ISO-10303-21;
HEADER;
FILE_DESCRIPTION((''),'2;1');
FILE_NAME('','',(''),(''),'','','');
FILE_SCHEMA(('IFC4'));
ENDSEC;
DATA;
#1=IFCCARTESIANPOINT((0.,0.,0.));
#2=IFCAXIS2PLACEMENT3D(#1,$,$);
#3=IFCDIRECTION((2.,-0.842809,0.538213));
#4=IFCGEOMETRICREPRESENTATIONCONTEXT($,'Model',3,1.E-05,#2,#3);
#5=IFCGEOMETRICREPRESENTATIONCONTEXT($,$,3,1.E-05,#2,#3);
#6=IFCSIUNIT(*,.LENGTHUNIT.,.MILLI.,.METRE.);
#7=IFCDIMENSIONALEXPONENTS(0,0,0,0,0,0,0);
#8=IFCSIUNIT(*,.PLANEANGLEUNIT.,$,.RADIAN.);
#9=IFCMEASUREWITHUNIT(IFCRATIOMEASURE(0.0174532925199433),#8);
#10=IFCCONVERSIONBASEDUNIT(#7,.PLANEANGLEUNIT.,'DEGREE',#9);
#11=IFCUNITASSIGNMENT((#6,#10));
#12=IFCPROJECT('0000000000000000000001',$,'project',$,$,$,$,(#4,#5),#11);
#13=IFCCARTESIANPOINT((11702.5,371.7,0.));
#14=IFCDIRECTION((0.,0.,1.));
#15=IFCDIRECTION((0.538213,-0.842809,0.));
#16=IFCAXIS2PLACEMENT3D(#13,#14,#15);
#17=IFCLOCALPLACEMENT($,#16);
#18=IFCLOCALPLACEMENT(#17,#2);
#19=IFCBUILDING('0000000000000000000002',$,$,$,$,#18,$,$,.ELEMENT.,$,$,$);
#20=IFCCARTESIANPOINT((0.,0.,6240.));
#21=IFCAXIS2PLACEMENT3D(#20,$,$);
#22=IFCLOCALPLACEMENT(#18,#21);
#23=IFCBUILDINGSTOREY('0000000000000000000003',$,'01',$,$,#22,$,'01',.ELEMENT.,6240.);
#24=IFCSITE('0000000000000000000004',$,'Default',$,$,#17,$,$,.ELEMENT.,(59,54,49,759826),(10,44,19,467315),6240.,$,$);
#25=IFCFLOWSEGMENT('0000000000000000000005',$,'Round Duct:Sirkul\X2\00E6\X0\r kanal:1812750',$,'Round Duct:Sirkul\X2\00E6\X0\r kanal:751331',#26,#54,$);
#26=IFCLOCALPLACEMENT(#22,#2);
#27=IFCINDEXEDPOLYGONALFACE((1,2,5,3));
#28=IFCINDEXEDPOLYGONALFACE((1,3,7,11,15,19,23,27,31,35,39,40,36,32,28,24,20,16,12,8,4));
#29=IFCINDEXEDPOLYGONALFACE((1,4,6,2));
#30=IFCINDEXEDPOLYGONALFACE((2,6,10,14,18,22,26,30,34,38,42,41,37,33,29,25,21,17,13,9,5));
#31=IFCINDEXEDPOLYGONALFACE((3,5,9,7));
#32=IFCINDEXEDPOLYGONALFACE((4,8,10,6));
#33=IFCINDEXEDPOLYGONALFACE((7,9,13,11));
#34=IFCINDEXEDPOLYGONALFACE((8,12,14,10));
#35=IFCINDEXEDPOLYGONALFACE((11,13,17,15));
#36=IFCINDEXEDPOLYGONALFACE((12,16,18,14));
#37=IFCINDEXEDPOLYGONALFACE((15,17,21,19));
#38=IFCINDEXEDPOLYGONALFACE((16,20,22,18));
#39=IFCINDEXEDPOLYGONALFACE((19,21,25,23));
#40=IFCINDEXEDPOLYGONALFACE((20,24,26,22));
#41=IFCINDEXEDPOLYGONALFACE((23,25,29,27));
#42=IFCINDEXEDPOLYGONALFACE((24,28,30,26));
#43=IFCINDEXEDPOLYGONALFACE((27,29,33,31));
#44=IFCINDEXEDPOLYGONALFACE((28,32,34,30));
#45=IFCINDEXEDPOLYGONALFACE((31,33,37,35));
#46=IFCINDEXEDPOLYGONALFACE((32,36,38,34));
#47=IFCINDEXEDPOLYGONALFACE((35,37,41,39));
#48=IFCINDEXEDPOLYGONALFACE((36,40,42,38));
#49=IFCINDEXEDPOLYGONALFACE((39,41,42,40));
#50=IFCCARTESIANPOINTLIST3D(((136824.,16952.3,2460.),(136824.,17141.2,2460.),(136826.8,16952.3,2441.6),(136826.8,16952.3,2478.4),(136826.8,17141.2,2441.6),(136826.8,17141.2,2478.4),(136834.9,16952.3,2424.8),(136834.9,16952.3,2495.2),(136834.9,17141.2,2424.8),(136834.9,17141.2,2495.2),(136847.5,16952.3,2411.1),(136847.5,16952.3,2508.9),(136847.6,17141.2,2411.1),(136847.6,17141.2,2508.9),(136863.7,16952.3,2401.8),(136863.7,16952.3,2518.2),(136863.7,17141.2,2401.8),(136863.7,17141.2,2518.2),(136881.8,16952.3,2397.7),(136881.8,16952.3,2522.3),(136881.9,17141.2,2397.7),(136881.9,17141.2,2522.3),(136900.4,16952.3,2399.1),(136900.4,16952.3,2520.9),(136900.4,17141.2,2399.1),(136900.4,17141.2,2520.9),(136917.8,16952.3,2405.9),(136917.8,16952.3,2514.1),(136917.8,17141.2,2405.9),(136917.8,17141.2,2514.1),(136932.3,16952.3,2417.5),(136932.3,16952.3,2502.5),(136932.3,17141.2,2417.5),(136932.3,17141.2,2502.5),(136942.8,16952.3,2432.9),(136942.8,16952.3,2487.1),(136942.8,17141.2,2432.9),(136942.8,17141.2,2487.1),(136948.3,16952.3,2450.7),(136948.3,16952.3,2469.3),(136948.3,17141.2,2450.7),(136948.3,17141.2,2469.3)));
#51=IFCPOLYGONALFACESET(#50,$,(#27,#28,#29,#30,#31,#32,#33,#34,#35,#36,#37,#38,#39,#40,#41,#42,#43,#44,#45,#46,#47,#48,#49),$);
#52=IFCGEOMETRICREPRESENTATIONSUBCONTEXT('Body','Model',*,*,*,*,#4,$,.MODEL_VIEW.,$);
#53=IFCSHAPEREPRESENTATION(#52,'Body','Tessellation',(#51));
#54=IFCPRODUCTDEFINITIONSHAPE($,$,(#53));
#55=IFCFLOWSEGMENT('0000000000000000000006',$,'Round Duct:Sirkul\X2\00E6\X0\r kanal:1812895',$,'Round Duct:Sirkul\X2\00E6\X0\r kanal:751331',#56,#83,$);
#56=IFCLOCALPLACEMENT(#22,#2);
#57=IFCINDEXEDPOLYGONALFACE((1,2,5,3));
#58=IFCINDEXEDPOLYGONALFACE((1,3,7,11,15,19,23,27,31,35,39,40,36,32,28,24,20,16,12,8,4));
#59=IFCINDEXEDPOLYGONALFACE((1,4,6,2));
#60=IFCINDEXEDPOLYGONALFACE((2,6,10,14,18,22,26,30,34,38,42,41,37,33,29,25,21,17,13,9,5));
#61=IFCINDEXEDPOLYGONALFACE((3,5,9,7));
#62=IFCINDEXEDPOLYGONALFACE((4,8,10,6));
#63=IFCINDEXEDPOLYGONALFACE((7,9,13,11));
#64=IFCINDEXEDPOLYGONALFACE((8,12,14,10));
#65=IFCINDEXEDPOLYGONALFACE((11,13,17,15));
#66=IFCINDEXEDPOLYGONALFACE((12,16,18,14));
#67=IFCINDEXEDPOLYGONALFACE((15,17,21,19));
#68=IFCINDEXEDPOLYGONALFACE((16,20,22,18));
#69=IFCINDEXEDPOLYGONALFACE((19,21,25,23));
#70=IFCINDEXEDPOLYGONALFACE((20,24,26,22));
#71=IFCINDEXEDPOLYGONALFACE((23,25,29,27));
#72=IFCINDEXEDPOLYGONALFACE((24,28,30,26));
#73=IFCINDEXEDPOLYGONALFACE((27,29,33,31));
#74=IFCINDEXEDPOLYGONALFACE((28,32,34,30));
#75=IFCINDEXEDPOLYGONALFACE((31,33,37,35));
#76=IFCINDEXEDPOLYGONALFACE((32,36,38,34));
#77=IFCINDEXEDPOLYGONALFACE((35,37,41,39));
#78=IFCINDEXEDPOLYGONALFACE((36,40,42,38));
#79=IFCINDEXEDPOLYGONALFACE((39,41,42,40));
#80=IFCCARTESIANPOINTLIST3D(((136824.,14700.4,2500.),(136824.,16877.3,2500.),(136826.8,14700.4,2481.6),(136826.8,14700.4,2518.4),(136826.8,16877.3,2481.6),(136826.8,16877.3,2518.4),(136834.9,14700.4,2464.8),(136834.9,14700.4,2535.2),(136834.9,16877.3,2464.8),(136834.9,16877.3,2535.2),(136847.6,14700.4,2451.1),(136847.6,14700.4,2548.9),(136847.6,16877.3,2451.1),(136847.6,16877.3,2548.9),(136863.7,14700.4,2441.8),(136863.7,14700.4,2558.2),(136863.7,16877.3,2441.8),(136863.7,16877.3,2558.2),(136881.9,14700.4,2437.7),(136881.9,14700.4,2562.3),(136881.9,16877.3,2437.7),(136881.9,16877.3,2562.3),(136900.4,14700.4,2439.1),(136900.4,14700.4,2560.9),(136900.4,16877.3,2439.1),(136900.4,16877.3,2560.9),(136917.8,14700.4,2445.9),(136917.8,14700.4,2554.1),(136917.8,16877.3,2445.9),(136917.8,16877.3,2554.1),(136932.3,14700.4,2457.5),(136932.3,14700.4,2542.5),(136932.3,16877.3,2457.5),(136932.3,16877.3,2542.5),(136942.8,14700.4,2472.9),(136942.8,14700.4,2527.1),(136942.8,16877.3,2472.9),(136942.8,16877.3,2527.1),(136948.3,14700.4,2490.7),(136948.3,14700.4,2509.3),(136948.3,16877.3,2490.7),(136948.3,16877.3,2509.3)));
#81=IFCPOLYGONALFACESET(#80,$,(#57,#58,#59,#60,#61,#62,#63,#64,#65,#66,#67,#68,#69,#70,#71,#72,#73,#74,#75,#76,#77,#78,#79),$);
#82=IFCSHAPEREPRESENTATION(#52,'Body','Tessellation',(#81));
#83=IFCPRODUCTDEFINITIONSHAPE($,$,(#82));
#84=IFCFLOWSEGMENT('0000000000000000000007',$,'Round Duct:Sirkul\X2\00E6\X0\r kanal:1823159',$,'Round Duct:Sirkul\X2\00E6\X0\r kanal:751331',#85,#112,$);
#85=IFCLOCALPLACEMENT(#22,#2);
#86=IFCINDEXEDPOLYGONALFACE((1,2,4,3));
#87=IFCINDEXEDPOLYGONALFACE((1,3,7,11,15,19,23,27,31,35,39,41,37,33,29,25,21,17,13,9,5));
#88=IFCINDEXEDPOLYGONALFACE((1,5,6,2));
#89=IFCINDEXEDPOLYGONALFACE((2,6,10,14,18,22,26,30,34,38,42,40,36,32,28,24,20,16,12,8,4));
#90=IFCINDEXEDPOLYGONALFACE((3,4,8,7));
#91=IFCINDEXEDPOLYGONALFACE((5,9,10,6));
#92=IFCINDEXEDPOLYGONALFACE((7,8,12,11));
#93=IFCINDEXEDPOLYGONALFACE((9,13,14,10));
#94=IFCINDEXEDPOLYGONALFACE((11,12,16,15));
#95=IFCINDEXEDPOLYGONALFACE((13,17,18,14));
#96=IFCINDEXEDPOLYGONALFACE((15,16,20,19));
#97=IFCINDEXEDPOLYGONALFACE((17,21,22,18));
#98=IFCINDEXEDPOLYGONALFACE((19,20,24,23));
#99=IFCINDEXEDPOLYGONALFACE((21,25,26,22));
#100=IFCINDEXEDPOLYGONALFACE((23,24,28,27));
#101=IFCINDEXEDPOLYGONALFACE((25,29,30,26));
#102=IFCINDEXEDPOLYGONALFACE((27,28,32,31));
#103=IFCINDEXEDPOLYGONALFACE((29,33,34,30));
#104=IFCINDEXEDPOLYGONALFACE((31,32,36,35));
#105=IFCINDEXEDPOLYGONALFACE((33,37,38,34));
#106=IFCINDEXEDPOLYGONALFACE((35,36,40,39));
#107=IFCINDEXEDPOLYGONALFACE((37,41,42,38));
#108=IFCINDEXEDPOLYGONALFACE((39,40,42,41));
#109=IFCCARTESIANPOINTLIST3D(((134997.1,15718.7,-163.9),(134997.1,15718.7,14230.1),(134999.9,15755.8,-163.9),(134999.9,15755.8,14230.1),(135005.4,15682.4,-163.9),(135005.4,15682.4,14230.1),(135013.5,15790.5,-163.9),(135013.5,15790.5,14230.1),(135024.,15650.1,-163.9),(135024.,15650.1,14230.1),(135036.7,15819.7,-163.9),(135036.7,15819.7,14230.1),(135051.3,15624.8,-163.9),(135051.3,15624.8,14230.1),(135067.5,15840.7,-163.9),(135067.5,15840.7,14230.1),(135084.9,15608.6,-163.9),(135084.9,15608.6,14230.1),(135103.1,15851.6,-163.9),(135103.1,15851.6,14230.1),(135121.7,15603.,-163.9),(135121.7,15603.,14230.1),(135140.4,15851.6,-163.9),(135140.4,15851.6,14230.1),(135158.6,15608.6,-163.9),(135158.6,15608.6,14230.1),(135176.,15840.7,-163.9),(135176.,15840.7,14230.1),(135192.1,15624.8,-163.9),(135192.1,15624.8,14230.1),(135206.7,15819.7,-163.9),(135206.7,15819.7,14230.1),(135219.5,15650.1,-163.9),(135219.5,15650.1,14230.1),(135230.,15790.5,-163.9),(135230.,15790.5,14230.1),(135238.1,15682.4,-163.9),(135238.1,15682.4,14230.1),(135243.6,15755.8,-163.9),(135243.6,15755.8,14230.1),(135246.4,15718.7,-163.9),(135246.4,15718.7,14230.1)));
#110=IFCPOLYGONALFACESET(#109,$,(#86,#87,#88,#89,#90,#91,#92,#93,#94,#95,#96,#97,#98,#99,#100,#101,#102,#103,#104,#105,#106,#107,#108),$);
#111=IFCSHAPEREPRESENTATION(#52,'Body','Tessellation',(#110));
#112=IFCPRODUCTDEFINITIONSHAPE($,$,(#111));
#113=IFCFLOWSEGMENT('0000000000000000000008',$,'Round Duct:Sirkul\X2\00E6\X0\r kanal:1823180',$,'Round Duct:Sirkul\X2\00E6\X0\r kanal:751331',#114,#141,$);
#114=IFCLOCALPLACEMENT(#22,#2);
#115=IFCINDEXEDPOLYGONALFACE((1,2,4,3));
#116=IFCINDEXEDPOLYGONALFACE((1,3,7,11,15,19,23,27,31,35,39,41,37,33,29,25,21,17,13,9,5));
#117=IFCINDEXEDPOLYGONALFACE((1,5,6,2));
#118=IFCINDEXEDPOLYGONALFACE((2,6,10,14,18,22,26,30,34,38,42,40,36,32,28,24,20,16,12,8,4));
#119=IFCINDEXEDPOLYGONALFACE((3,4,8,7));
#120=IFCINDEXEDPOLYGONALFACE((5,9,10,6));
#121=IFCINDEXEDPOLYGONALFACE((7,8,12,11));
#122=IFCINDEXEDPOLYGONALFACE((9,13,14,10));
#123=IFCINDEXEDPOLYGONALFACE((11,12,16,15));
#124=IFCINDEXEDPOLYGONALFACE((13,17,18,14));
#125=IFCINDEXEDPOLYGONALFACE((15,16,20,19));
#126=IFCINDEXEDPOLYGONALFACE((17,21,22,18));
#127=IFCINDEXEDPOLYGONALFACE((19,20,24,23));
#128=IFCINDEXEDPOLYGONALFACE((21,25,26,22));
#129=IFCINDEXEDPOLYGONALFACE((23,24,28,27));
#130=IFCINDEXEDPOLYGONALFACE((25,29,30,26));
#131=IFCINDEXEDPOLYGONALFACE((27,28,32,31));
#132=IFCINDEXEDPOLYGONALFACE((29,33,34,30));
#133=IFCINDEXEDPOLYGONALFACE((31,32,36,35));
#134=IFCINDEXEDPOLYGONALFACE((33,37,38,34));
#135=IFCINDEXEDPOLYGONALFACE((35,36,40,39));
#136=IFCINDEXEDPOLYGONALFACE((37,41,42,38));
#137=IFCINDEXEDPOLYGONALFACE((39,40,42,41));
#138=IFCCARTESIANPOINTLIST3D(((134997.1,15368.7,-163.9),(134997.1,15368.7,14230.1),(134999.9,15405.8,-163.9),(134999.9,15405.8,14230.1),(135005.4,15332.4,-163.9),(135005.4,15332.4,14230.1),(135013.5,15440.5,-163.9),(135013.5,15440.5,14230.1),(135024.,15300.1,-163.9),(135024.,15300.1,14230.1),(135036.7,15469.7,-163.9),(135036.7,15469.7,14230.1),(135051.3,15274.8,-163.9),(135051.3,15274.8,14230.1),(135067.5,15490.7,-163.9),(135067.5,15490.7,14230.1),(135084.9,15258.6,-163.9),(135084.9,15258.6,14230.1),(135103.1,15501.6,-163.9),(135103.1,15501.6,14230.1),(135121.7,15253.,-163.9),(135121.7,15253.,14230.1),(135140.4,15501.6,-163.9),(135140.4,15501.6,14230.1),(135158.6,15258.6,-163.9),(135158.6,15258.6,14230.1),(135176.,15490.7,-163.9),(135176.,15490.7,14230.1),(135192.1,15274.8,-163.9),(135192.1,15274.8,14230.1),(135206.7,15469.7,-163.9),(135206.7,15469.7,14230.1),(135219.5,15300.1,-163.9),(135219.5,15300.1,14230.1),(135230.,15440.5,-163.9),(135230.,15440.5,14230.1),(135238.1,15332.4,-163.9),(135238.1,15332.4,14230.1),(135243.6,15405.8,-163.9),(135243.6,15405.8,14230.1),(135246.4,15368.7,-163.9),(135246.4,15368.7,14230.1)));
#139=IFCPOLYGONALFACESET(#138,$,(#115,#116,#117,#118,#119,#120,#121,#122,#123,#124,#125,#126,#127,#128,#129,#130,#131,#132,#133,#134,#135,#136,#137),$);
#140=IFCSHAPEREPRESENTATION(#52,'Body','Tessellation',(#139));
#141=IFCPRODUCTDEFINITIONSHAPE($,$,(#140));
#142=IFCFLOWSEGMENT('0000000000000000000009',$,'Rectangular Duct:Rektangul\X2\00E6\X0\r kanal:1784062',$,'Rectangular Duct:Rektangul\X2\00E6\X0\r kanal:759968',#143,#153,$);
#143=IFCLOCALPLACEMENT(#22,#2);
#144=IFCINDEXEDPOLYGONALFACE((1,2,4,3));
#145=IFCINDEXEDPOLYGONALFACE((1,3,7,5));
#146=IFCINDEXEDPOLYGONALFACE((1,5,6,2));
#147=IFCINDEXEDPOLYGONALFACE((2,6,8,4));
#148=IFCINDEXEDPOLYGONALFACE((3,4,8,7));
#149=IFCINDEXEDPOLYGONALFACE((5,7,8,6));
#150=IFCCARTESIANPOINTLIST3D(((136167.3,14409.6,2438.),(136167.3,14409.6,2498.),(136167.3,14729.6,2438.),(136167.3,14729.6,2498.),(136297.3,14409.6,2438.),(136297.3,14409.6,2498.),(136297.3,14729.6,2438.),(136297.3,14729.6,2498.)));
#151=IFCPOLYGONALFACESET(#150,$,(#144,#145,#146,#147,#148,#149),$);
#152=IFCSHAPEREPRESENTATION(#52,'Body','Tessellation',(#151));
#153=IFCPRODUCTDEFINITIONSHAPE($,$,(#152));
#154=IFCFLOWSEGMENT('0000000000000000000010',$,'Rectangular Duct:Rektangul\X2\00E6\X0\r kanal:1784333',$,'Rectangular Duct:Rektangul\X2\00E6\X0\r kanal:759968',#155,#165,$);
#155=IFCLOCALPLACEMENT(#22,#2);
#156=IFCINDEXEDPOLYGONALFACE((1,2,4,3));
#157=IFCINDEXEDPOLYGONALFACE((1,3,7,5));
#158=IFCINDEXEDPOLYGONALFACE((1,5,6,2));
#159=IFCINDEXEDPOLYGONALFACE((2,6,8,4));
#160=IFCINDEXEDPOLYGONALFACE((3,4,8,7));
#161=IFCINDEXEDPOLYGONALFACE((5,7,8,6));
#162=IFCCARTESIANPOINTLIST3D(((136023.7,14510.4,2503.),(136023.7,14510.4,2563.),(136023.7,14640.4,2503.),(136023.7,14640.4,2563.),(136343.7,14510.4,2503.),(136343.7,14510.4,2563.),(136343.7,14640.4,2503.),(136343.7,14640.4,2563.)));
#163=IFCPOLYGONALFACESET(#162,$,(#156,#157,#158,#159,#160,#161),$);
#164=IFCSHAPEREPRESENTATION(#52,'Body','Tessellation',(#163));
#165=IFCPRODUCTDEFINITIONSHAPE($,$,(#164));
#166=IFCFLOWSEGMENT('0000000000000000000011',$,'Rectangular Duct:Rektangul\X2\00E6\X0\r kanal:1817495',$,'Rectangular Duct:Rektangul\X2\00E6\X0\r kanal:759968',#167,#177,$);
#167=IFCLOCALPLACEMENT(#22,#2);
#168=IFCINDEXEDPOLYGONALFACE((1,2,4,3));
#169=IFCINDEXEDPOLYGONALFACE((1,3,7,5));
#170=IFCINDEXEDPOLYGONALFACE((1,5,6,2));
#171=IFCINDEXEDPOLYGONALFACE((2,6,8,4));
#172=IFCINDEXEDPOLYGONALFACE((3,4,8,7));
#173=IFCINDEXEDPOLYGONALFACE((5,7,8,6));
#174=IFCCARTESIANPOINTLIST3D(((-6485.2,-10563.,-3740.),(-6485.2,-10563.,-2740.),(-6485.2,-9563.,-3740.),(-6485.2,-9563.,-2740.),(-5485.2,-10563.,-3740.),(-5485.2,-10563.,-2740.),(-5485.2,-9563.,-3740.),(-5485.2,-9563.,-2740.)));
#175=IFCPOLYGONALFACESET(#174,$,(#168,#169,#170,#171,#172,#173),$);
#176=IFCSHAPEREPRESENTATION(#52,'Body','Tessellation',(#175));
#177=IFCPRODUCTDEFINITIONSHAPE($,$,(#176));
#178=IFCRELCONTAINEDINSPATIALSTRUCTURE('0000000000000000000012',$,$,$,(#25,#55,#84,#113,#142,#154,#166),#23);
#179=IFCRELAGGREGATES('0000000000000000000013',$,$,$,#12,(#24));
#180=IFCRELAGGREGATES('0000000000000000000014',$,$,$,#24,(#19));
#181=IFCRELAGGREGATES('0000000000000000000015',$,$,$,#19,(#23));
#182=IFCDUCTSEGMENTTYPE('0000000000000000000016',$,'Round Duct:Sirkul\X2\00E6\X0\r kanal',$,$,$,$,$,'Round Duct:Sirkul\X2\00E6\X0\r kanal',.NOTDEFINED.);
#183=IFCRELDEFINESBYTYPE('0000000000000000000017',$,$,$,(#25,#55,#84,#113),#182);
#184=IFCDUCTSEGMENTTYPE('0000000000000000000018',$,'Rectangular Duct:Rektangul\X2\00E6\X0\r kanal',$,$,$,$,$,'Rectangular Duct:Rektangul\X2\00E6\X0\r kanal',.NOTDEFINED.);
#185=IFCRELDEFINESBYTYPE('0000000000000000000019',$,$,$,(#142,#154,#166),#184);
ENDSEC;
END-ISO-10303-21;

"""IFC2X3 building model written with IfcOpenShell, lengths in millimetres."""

from ifc_helpers import new_model, entity, si_unit, converted_unit, direction, frame, frame_2d, origin, origin_2d_with_axis, place, context, subcontext, project, spatial, rectangle, circle, extrude, type_object, element, save


model = new_model("IFC2X3")

# Units and contexts
model_context = context("Model", 3, precision=1e-05, world=origin(), true_north=direction((2.0, -0.842809, 0.538213)))
context_of_model = context(None, 3, precision=1e-05, world=origin(), true_north=direction((2.0, -0.842809, 0.538213)))
body_context = subcontext(model_context, "Body", "Model", "MODEL_VIEW")
ifc_project = project(units=[si_unit("LENGTHUNIT", "METRE", prefix="MILLI"), converted_unit("PLANEANGLEUNIT", "DEGREE", entity("IfcRatioMeasure", 0.0174532925199433), si_unit("PLANEANGLEUNIT", "RADIAN"), dimensions=[0, 0, 0, 0, 0, 0, 0])], contexts=[model_context, context_of_model])

# Site, building, storey
site_placement = place(None, frame((11702.5, 371.7, 0.0), z_axis=(0.0, 0.0, 1.0), x_axis=(0.538213, -0.842809, 0.0)))
site = spatial("IfcSite", under=ifc_project, at=site_placement, Name="Default", CompositionType="ELEMENT", RefLatitude=(59, 54, 49, 759826), RefLongitude=(10, 44, 19, 467315), RefElevation=6240.0)
building_placement = place(site_placement, origin())
building = spatial("IfcBuilding", under=site, at=building_placement, CompositionType="ELEMENT")
storey_placement = place(building_placement, frame((0.0, 0.0, 6240.0)))
storey = spatial("IfcBuildingStorey", under=building, at=storey_placement, Name="01", LongName="01", CompositionType="ELEMENT", Elevation=6240.0)

# Flow segments
duct_segment_type_1 = type_object("IfcDuctSegmentType", Name="Round Duct:Sirkulær kanal", ElementType="Round Duct:Sirkulær kanal", PredefinedType="NOTDEFINED")
flow_segment_1_placement = place(storey_placement, origin())
element("IfcFlowSegment", 1, at=flow_segment_1_placement, inside=storey, type_object=duct_segment_type_1, Name="Round Duct:Sirkulær kanal:1812750", ObjectType="Round Duct:Sirkulær kanal:751331", context=body_context, shape_type="SweptSolid", body=[
    extrude(circle(Radius=62.5, at=frame_2d((0.0, 0.0), x_axis=(1.0, 0.0))), frame((136886.5, 16952.3, 2460.0), z_axis=(0.000037, 1.0, 0.0), x_axis=(-1.0, 0.000037, 0.0)), (0.0, 0.0, 1.0), 188.9),
])
flow_segment_2_placement = place(storey_placement, origin())
element("IfcFlowSegment", 2, at=flow_segment_2_placement, inside=storey, type_object=duct_segment_type_1, Name="Round Duct:Sirkulær kanal:1812895", ObjectType="Round Duct:Sirkulær kanal:751331", context=body_context, shape_type="SweptSolid", body=[
    extrude(circle(Radius=62.5, at=origin_2d_with_axis()), frame((136886.5, 14700.4, 2500.0), z_axis=(0.0, 1.0, 0.0), x_axis=(-1.0, 0.0, 0.0)), (0.0, 0.0, 1.0), 2176.9),
])
flow_segment_3_placement = place(storey_placement, origin())
element("IfcFlowSegment", 3, at=flow_segment_3_placement, inside=storey, type_object=duct_segment_type_1, Name="Round Duct:Sirkulær kanal:1823159", ObjectType="Round Duct:Sirkulær kanal:751331", context=body_context, shape_type="SweptSolid", body=[
    extrude(circle(Radius=125.0, at=frame_2d((0.0, 0.0), x_axis=(1.0, 0.0))), frame((135121.7, 15728.0, -163.9), z_axis=(0.0, 0.0, 1.0), x_axis=(0.0, -1.0, 0.0)), (0.0, 0.0, 1.0), 14394.0),
])
flow_segment_4_placement = place(storey_placement, origin())
element("IfcFlowSegment", 4, at=flow_segment_4_placement, inside=storey, type_object=duct_segment_type_1, Name="Round Duct:Sirkulær kanal:1823180", ObjectType="Round Duct:Sirkulær kanal:751331", context=body_context, shape_type="SweptSolid", body=[
    extrude(circle(Radius=125.0, at=frame_2d((0.0, 0.0), x_axis=(1.0, 0.0))), frame((135121.7, 15378.0, -163.9), z_axis=(0.0, 0.0, 1.0), x_axis=(0.0, -1.0, 0.0)), (0.0, 0.0, 1.0), 14394.0),
])
duct_segment_type_2 = type_object("IfcDuctSegmentType", Name="Rectangular Duct:Rektangulær kanal", ElementType="Rectangular Duct:Rektangulær kanal", PredefinedType="NOTDEFINED")
flow_segment_5_placement = place(storey_placement, origin())
element("IfcFlowSegment", 5, at=flow_segment_5_placement, inside=storey, type_object=duct_segment_type_2, Name="Rectangular Duct:Rektangulær kanal:1784062", ObjectType="Rectangular Duct:Rektangulær kanal:759968", context=body_context, shape_type="SweptSolid", body=[
    extrude(rectangle(XDim=320.0, YDim=130.0, at=origin_2d_with_axis()), frame((136232.3, 14569.6, 2438.0), z_axis=(0.0, 0.0, 1.0), x_axis=(0.0, 1.0, 0.0)), (0.0, 0.0, 1.0), 60.0),
])
flow_segment_6_placement = place(storey_placement, origin())
element("IfcFlowSegment", 6, at=flow_segment_6_placement, inside=storey, type_object=duct_segment_type_2, Name="Rectangular Duct:Rektangulær kanal:1784333", ObjectType="Rectangular Duct:Rektangulær kanal:759968", context=body_context, shape_type="SweptSolid", body=[
    extrude(rectangle(XDim=320.0, YDim=130.0, at=origin_2d_with_axis()), frame((136183.7, 14575.4, 2503.0)), (0.0, 0.0, 1.0), 60.0),
])
flow_segment_7_placement = place(storey_placement, origin())
element("IfcFlowSegment", 7, at=flow_segment_7_placement, inside=storey, type_object=duct_segment_type_2, Name="Rectangular Duct:Rektangulær kanal:1817495", ObjectType="Rectangular Duct:Rektangulær kanal:759968", context=body_context, shape_type="SweptSolid", body=[
    extrude(rectangle(XDim=1000.0, YDim=1000.0, at=frame_2d((0.0, 0.0), x_axis=(1.0, 0.0))), frame((-5985.2, -10063.0, -3740.0), z_axis=(0.0, 0.0, 1.0), x_axis=(0.0, -1.0, 0.0)), (0.0, 0.0, 1.0), 1000.0),
])

save(model, "model.ifc")
